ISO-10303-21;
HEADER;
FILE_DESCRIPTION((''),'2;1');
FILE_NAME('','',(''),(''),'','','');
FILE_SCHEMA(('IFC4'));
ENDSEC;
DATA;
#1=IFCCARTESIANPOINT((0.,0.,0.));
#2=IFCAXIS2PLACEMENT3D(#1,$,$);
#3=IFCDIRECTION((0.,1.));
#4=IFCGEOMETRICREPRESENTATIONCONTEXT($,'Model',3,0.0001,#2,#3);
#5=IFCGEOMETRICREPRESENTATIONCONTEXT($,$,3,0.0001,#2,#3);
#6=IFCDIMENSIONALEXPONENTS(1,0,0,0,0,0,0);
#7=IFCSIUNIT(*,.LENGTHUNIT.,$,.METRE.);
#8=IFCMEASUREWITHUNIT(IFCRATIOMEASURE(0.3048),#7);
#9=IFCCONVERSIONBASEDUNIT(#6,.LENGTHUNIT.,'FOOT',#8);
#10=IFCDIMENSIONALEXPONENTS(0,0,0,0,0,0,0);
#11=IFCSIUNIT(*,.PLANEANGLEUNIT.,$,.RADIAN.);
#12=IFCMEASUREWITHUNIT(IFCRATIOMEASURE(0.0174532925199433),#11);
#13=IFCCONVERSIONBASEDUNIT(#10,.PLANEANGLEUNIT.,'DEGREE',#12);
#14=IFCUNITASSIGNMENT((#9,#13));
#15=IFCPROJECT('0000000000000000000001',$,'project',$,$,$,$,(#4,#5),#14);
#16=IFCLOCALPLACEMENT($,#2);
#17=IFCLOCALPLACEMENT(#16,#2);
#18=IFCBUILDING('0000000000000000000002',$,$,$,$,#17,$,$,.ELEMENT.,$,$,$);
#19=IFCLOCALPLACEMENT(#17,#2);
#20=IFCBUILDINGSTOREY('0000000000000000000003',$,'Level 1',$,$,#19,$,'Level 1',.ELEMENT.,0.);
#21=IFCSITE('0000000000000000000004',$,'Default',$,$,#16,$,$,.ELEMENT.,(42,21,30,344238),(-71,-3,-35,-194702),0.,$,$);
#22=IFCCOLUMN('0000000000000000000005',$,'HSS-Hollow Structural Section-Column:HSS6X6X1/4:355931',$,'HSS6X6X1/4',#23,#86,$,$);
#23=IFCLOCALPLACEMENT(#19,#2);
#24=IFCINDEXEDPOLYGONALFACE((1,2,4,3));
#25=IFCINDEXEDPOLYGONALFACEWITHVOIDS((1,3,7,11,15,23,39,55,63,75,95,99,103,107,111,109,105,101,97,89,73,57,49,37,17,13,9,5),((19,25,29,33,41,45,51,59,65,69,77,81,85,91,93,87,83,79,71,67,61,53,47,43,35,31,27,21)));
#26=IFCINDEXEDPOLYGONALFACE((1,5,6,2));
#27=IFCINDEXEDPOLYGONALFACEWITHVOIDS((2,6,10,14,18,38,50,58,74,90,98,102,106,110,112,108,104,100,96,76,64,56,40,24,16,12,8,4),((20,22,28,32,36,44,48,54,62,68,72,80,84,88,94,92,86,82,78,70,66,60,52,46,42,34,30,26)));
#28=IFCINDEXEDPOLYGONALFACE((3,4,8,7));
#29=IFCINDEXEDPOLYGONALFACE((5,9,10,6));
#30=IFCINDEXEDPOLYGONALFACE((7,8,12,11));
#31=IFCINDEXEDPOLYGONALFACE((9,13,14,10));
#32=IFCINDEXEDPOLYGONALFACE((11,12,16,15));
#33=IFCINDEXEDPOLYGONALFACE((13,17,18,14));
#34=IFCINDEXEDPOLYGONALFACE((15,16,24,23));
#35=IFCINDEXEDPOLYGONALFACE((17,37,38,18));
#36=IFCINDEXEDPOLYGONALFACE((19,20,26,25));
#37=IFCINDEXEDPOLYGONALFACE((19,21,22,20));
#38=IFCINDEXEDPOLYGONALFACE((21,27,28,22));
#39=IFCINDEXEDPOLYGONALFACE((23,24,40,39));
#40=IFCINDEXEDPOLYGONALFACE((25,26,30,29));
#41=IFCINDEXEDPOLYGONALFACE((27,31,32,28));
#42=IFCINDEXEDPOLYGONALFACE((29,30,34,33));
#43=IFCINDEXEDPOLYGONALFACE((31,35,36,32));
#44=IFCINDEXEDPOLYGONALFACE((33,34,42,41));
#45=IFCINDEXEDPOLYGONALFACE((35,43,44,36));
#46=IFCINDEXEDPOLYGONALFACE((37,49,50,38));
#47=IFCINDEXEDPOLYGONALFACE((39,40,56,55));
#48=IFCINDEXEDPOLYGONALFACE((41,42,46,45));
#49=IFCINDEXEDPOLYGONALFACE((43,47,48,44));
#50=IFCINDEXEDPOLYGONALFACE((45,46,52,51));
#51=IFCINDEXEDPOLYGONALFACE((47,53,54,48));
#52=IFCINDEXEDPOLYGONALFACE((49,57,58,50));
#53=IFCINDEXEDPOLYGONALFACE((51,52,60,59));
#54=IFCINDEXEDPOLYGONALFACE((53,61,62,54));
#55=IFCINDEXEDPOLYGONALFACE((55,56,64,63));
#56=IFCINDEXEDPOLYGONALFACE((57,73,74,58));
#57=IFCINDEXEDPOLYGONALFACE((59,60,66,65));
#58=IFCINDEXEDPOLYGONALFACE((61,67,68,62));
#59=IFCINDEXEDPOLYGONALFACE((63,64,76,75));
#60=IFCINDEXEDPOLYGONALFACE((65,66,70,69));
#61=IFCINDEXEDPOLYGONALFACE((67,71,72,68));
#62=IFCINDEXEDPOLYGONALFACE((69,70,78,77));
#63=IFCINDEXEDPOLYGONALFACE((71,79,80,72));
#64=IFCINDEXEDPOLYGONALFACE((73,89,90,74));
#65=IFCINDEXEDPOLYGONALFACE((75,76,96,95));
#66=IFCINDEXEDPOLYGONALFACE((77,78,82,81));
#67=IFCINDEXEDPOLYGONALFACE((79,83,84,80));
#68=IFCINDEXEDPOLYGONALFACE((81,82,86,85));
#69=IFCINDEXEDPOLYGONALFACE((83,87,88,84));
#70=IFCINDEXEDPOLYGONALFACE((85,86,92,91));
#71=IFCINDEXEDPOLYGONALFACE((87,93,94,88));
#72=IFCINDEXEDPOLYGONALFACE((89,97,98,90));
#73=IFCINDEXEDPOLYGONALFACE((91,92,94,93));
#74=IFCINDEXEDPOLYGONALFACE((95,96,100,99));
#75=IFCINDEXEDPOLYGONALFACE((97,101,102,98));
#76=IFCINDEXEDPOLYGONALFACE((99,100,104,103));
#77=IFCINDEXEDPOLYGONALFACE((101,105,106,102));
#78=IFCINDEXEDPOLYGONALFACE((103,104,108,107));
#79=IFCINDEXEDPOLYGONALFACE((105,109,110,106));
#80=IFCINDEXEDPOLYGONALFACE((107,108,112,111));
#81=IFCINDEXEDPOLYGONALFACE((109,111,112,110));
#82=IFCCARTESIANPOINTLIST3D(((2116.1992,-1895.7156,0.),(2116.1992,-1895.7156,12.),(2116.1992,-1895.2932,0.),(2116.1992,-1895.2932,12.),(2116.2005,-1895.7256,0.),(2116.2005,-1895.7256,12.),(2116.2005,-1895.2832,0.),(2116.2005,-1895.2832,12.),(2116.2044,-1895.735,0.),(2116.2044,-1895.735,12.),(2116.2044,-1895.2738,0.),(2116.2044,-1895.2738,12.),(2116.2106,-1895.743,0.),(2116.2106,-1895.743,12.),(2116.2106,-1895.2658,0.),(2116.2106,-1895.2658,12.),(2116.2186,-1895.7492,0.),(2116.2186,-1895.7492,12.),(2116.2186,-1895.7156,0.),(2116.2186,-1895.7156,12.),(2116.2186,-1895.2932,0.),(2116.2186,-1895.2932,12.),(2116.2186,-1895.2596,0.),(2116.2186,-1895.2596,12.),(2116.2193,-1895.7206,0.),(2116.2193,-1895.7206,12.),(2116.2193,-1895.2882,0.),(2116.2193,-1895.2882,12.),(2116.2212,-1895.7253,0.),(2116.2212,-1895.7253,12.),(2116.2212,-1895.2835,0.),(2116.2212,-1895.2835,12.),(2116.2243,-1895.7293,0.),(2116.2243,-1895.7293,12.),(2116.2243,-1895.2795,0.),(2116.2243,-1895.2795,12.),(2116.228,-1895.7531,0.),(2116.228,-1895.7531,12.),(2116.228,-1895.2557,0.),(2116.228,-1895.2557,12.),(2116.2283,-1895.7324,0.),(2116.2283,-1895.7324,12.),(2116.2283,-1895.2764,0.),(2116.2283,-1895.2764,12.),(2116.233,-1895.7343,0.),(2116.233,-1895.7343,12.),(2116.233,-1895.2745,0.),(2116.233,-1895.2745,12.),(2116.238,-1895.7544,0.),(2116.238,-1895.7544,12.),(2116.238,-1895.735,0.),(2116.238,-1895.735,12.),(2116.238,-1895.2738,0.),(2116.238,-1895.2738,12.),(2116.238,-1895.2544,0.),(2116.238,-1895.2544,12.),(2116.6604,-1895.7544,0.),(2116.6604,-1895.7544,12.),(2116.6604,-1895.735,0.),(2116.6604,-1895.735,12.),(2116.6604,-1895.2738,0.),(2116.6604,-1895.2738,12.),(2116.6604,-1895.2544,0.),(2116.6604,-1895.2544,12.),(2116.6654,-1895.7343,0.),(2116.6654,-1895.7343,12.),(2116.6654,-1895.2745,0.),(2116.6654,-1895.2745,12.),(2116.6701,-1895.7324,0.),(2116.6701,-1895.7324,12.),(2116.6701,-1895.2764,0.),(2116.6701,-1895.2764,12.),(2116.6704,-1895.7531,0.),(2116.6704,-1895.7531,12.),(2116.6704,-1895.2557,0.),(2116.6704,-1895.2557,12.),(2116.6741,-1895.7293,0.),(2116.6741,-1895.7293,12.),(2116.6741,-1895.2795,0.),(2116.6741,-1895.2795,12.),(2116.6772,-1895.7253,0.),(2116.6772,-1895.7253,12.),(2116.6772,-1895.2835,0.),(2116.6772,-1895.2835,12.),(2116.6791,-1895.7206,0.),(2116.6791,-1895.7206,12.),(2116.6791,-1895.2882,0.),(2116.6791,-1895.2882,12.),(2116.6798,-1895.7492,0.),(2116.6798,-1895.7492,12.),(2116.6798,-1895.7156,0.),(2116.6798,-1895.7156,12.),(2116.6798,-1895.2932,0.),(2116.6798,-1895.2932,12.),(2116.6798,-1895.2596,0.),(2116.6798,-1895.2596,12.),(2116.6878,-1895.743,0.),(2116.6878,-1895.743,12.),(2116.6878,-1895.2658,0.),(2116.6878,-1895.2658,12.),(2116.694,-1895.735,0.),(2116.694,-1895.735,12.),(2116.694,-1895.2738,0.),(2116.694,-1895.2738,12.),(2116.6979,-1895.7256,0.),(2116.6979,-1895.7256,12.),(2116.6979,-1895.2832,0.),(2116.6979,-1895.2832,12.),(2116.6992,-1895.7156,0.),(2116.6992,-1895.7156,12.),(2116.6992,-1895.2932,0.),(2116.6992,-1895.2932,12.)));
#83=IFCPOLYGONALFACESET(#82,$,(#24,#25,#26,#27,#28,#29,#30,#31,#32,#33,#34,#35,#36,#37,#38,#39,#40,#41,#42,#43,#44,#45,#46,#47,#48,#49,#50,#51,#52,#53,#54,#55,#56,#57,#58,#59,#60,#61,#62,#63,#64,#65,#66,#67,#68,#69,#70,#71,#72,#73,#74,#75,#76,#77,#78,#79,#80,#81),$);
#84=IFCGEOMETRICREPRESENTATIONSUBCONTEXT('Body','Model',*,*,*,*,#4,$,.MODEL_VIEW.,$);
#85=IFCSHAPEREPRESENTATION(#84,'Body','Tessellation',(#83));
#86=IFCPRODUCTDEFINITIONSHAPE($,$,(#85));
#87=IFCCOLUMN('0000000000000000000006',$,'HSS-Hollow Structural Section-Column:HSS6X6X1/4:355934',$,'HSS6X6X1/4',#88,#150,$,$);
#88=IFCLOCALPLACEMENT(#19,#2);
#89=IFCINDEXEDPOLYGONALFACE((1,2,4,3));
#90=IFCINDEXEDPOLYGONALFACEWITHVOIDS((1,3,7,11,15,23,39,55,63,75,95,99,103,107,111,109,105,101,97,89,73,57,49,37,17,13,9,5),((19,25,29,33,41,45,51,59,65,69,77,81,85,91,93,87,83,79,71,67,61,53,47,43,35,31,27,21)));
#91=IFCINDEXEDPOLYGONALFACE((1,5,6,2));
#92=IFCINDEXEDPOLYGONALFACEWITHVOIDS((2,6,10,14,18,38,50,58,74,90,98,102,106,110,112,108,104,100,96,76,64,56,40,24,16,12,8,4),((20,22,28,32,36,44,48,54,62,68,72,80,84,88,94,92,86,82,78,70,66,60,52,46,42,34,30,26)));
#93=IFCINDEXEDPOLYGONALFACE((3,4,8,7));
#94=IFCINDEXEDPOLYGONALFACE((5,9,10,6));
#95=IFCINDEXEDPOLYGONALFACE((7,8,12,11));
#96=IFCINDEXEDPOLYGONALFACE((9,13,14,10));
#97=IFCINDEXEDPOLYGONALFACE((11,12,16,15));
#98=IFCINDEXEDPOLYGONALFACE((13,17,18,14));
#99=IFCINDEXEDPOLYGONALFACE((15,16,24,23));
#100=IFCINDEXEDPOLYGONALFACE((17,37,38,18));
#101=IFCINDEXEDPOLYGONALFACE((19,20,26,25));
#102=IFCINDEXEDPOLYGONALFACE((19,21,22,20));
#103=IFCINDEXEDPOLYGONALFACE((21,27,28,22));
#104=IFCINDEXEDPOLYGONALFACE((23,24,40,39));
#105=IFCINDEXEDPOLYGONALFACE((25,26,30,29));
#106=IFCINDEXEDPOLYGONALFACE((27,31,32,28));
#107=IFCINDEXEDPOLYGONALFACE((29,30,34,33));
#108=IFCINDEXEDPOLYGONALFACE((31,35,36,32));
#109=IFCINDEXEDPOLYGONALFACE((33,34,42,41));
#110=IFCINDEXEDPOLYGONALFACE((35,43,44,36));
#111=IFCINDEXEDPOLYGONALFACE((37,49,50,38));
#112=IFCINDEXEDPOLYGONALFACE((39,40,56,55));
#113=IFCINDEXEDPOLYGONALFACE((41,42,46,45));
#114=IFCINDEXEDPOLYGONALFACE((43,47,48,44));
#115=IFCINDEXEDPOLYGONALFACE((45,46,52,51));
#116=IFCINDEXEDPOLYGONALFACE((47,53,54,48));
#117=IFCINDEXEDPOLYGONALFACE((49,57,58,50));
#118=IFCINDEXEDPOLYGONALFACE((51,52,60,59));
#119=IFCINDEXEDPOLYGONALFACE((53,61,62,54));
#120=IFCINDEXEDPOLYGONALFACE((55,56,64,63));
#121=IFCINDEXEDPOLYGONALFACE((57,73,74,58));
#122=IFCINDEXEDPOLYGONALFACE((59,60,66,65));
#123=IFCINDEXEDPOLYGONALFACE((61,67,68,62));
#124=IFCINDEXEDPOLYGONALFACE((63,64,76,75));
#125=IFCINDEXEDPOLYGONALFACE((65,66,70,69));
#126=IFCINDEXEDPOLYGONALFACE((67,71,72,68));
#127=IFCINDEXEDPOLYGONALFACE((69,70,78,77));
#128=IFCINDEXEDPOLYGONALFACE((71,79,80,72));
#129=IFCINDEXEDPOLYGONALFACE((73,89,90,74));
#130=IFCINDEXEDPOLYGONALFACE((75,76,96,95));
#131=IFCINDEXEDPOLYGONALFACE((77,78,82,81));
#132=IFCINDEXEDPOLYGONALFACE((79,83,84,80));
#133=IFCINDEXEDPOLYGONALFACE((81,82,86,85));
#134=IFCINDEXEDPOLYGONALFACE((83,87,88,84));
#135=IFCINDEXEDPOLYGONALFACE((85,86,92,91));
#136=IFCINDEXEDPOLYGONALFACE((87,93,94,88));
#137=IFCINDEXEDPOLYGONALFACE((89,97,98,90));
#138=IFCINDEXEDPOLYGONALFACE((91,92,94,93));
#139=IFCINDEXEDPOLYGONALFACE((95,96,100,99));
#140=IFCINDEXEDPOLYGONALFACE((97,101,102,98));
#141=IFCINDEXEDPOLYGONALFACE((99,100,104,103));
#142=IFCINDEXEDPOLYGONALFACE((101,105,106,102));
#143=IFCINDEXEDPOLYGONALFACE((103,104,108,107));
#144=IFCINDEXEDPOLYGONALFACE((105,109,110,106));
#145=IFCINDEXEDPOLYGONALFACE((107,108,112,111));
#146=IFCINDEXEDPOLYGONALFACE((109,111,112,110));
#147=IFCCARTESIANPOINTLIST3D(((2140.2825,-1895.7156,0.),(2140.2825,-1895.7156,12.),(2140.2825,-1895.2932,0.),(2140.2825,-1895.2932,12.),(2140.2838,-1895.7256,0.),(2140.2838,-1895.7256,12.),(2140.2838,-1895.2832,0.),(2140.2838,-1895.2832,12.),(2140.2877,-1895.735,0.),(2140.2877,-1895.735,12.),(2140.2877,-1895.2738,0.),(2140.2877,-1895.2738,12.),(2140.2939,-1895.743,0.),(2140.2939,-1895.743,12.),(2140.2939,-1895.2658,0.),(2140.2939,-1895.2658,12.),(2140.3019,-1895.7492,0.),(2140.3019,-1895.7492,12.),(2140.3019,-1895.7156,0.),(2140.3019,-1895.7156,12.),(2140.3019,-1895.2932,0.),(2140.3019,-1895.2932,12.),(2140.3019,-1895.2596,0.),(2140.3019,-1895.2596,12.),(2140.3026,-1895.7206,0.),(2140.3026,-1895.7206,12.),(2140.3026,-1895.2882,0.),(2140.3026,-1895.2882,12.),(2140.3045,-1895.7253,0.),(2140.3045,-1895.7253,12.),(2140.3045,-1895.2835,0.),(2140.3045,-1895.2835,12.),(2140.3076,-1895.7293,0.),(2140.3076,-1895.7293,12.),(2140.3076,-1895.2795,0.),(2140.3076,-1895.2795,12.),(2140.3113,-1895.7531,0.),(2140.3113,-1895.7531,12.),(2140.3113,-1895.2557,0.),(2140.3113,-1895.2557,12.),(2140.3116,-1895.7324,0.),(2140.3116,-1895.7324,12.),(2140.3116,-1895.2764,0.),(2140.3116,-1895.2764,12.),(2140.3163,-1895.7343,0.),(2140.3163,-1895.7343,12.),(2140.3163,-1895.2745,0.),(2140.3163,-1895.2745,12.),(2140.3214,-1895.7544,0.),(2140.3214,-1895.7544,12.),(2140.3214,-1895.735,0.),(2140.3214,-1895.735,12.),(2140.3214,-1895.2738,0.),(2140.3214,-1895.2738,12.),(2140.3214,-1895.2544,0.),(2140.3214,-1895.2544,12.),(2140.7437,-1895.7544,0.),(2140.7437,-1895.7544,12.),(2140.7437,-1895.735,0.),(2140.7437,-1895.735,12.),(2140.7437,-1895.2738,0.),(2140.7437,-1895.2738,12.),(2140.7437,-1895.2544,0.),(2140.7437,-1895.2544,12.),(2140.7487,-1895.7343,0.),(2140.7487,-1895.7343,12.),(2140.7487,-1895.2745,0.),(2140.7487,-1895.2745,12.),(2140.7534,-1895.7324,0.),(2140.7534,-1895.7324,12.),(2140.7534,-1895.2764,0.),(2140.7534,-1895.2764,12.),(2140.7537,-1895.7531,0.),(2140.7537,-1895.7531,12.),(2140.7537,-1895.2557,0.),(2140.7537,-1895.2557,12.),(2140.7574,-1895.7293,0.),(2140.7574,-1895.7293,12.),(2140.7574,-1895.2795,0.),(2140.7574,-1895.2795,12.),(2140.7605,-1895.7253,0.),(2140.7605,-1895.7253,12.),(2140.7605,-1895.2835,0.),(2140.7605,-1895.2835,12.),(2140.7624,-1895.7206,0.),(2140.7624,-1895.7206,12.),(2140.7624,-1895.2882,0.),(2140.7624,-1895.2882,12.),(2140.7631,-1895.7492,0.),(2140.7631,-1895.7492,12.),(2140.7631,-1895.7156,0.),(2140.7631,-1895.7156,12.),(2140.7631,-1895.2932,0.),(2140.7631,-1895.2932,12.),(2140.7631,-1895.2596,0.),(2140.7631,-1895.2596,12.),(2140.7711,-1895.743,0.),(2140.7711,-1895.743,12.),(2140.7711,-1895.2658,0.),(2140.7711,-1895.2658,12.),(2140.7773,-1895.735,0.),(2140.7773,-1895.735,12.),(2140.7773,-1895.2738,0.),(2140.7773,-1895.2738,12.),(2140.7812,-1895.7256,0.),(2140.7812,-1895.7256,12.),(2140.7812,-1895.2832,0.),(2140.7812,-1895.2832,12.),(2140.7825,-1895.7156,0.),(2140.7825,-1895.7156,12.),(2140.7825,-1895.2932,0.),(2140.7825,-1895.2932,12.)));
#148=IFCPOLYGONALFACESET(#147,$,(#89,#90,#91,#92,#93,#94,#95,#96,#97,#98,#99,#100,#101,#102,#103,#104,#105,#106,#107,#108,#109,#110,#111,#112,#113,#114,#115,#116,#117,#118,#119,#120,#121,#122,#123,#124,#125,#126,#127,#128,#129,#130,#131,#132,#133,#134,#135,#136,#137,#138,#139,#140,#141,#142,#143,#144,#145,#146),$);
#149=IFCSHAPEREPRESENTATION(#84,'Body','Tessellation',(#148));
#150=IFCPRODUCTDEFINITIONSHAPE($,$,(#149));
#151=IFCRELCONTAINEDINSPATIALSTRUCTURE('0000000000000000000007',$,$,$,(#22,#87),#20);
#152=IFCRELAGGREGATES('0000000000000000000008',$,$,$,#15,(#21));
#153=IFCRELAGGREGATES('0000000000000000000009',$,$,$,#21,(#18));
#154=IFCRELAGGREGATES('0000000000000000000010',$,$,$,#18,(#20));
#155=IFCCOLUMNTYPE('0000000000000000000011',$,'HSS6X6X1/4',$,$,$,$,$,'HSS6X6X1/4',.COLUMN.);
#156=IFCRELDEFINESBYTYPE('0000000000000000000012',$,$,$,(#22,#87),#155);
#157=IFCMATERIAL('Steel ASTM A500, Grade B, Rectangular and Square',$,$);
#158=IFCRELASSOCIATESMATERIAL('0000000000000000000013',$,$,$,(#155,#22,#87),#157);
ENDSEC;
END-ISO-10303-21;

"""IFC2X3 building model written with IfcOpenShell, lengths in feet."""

from ifc_helpers import new_model, entity, si_unit, converted_unit, direction, frame, frame_2d, origin, place, context, subcontext, project, spatial, polyline, circle_curve, parameter, trimmed, segment, composite_curve, outline, extrude, source, transform, mapped, material, type_object, type_shapes, element, save


model = new_model("IFC2X3")

# Units and contexts
model_context = context("Model", 3, precision=0.0001, world=origin(), true_north=direction((0.0, 1.0)))
context_of_model = context(None, 3, precision=0.0001, world=origin(), true_north=direction((0.0, 1.0)))
body_context = subcontext(model_context, "Body", "Model", "MODEL_VIEW")
ifc_project = project(units=[converted_unit("LENGTHUNIT", "FOOT", entity("IfcRatioMeasure", 0.3048), si_unit("LENGTHUNIT", "METRE"), dimensions=[1, 0, 0, 0, 0, 0, 0]), converted_unit("PLANEANGLEUNIT", "DEGREE", entity("IfcRatioMeasure", 0.0174532925199433), si_unit("PLANEANGLEUNIT", "RADIAN"), dimensions=[0, 0, 0, 0, 0, 0, 0])], contexts=[model_context, context_of_model])

# Site, building, storey
site_placement = place(None, origin())
site = spatial("IfcSite", under=ifc_project, at=site_placement, Name="Default", CompositionType="ELEMENT", RefLatitude=(42, 21, 30, 344238), RefLongitude=(-71, -3, -35, -194702), RefElevation=0.0)
building_placement = place(site_placement, origin())
building = spatial("IfcBuilding", under=site, at=building_placement, CompositionType="ELEMENT")
storey_placement = place(building_placement, origin())
storey = spatial("IfcBuildingStorey", under=building, at=storey_placement, Name="Level 1", LongName="Level 1", CompositionType="ELEMENT", Elevation=0.0)

# Columns
ifc_material_1 = material(Name="Steel ASTM A500, Grade B, Rectangular and Square")
column_type = type_object("IfcColumnType", Name="HSS6X6X1/4", ElementType="HSS6X6X1/4", PredefinedType="COLUMN", material=ifc_material_1)
shared_shape = source(origin(), body_context, "Body", "SweptSolid", [
    extrude(outline(composite_curve([segment(polyline([(-0.2112, -0.25), (0.2112, -0.25)]), True, "CONTINUOUS"), segment(trimmed(circle_curve(frame_2d((0.2112, -0.2112), x_axis=(-1.0, 0.0)), 0.0388), [parameter(90.0)], [parameter(180.0)], True, "PARAMETER"), True, "CONTINUOUS"), segment(polyline([(0.25, -0.2112), (0.25, 0.2112)]), True, "CONTINUOUS"), segment(trimmed(circle_curve(frame_2d((0.2112, 0.2112), x_axis=(-1.0, 0.0)), 0.0388), [parameter(180.0)], [parameter(270.0)], True, "PARAMETER"), True, "CONTINUOUS"), segment(polyline([(0.2112, 0.25), (-0.2112, 0.25)]), True, "CONTINUOUS"), segment(trimmed(circle_curve(frame_2d((-0.2112, 0.2112), x_axis=(-1.0, 0.0)), 0.0388), [parameter(270.0)], [parameter(360.0)], True, "PARAMETER"), True, "CONTINUOUS"), segment(polyline([(-0.25, 0.2112), (-0.25, -0.2112)]), True, "CONTINUOUS"), segment(trimmed(circle_curve(frame_2d((-0.2112, -0.2112), x_axis=(-1.0, 0.0)), 0.0388), [parameter(360.0)], [parameter(90.0)], True, "PARAMETER"), True, "CONTINUOUS")], self_intersect=False), holes=[composite_curve([segment(trimmed(circle_curve(frame_2d((-0.2112, -0.2112), x_axis=(-1.0, 0.0)), 0.0194), [parameter(0.0)], [parameter(90.0)], True, "PARAMETER"), False, "CONTINUOUS"), segment(polyline([(-0.2306, -0.2112), (-0.2306, 0.2112)]), True, "CONTINUOUS"), segment(trimmed(circle_curve(frame_2d((-0.2112, 0.2112), x_axis=(-1.0, 0.0)), 0.0194), [parameter(270.0)], [parameter(360.0)], True, "PARAMETER"), False, "CONTINUOUS"), segment(polyline([(-0.2112, 0.2306), (0.2112, 0.2306)]), True, "CONTINUOUS"), segment(trimmed(circle_curve(frame_2d((0.2112, 0.2112), x_axis=(-1.0, 0.0)), 0.0194), [parameter(180.0)], [parameter(270.0)], True, "PARAMETER"), False, "CONTINUOUS"), segment(polyline([(0.2306, 0.2112), (0.2306, -0.2112)]), True, "CONTINUOUS"), segment(trimmed(circle_curve(frame_2d((0.2112, -0.2112), x_axis=(-1.0, 0.0)), 0.0194), [parameter(90.0)], [parameter(180.0)], True, "PARAMETER"), False, "CONTINUOUS"), segment(polyline([(0.2112, -0.2306), (-0.2112, -0.2306)]), True, "CONTINUOUS")], self_intersect=False)]), frame((0.0, 0.0, 0.0), z_axis=(0.0, 0.0, 1.0), x_axis=(-1.0, 0.0, 0.0)), (0.0, 0.0, 1.0), 12.0),
])
type_shapes(column_type, [shared_shape])
for number, where, z_axis, x_axis, name in (
    (1, (2116.4492, -1895.5044, 0.0), (0.0, 0.0, 1.0), (-1.0, 0.0, 0.0), "HSS-Hollow Structural Section-Column:HSS6X6X1/4:355931"),
    (2, (2140.5325, -1895.5044, 0.0), (0.0, 0.0, 1.0), (-1.0, 0.0, 0.0), "HSS-Hollow Structural Section-Column:HSS6X6X1/4:355934"),
):
    element("IfcColumn", number, at=place(storey_placement, frame(where, z_axis=z_axis, x_axis=x_axis)), inside=storey, type_object=column_type, material=ifc_material_1, Name=name, ObjectType="HSS6X6X1/4", context=body_context, shape_type="MappedRepresentation", body=[
        mapped(shared_shape, transform((0.0, 0.0, 0.0), scale=1.0)),
    ])

save(model, "model.ifc")
